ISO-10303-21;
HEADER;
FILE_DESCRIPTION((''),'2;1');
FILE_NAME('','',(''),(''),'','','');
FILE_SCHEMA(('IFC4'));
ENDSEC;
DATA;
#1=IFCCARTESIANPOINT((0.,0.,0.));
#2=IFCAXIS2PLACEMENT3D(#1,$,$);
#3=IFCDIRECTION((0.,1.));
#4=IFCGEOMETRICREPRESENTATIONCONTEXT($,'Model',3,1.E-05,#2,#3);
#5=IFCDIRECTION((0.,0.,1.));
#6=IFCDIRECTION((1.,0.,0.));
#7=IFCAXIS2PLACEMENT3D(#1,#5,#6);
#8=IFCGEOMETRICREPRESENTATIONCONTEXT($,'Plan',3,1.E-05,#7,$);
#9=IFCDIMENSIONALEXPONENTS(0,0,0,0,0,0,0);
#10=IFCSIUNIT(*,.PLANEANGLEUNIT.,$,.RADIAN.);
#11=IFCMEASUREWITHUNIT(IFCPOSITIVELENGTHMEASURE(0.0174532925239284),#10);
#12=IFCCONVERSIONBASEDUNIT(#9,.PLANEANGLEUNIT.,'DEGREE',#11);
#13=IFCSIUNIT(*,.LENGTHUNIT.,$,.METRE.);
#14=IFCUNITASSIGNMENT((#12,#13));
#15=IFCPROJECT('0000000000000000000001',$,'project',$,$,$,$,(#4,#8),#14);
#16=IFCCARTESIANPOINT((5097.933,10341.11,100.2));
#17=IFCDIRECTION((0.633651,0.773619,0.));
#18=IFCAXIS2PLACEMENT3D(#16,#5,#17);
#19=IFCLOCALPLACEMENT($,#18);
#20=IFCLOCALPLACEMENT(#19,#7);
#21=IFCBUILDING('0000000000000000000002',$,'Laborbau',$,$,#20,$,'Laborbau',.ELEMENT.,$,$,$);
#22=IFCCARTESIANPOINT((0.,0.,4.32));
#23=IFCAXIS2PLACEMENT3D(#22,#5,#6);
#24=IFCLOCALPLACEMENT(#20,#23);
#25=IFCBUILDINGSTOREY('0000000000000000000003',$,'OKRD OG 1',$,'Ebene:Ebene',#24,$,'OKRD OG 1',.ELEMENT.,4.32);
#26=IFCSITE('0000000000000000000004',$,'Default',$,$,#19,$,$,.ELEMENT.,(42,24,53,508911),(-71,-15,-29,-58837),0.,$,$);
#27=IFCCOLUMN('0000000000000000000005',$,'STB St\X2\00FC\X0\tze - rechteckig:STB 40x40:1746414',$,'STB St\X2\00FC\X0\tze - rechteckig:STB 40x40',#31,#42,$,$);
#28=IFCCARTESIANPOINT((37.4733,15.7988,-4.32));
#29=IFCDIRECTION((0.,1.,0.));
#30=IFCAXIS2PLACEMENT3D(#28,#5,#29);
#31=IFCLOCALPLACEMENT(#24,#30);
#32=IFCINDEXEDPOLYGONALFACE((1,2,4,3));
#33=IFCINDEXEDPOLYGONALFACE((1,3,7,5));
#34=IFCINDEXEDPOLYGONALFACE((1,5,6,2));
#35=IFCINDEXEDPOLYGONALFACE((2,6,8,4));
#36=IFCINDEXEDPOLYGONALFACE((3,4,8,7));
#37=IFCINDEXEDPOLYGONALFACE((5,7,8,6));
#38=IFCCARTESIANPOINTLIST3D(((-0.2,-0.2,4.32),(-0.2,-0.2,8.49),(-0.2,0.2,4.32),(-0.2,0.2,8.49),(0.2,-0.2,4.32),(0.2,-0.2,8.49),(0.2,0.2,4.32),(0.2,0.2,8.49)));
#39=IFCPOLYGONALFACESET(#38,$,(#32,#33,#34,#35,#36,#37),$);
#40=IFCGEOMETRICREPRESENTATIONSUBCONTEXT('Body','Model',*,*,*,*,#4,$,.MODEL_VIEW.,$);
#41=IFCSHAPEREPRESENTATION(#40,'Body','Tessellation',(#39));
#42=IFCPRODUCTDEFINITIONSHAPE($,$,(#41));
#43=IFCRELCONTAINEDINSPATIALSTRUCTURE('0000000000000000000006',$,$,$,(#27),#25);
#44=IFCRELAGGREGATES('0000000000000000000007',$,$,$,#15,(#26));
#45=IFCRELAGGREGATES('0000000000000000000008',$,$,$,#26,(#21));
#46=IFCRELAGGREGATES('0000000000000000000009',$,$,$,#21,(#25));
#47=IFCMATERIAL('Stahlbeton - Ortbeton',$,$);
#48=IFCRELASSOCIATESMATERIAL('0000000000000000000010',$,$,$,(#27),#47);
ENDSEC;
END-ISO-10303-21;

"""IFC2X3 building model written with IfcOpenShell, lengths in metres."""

from ifc_helpers import new_model, entity, si_unit, converted_unit, direction, frame, origin, origin_with_axes, origin_2d_with_axis, place, context, subcontext, project, spatial, rectangle, extrude, source, transform, mapped, material, element, save


model = new_model("IFC2X3")

# Units and contexts
model_context = context("Model", 3, precision=1e-05, world=origin(), true_north=direction((0.0, 1.0)))
plan_context = context("Plan", 3, precision=1e-05, world=origin_with_axes())
body_context = subcontext(model_context, "Body", "Model", "MODEL_VIEW")
ifc_project = project(units=[converted_unit("PLANEANGLEUNIT", "DEGREE", entity("IfcPositiveLengthMeasure", 0.0174532925239284), si_unit("PLANEANGLEUNIT", "RADIAN"), dimensions=[0, 0, 0, 0, 0, 0, 0]), si_unit("LENGTHUNIT", "METRE")], contexts=[model_context, plan_context])

# Site, building, storey
site_placement = place(None, frame((5097.933, 10341.11, 100.2), z_axis=(0.0, 0.0, 1.0), x_axis=(0.633651, 0.773619, 0.0)))
site = spatial("IfcSite", under=ifc_project, at=site_placement, Name="Default", CompositionType="ELEMENT", RefLatitude=(42, 24, 53, 508911), RefLongitude=(-71, -15, -29, -58837), RefElevation=0.0)
building_placement = place(site_placement, origin_with_axes())
building = spatial("IfcBuilding", under=site, at=building_placement, Name="Laborbau", LongName="Laborbau", CompositionType="ELEMENT")
storey_placement = place(building_placement, frame((0.0, 0.0, 4.32), z_axis=(0.0, 0.0, 1.0), x_axis=(1.0, 0.0, 0.0)))
storey = spatial("IfcBuildingStorey", under=building, at=storey_placement, Name="OKRD OG 1", ObjectType="Ebene:Ebene", LongName="OKRD OG 1", CompositionType="ELEMENT", Elevation=4.32)

# Column
ifc_material_1 = material(Name="Stahlbeton - Ortbeton")
shared_shape = source(origin(), body_context, "Body", "SweptSolid", [
    extrude(rectangle(XDim=0.4, YDim=0.4, at=origin_2d_with_axis()), frame((0.0, 0.0, 4.32), z_axis=(0.0, 0.0, 1.0), x_axis=(0.0, -1.0, 0.0)), (0.0, 0.0, 1.0), 4.17),
])
column_placement = place(storey_placement, frame((37.4733, 15.7988, -4.32), z_axis=(0.0, 0.0, 1.0), x_axis=(0.0, 1.0, 0.0)))
element("IfcColumn", 1, at=column_placement, inside=storey, material=ifc_material_1, Name="STB Stütze - rechteckig:STB 40x40:1746414", ObjectType="STB Stütze - rechteckig:STB 40x40", context=body_context, shape_type="MappedRepresentation", body=[
    mapped(shared_shape, transform((0.0, 0.0, 0.0), scale=1.0)),
])

save(model, "model.ifc")
